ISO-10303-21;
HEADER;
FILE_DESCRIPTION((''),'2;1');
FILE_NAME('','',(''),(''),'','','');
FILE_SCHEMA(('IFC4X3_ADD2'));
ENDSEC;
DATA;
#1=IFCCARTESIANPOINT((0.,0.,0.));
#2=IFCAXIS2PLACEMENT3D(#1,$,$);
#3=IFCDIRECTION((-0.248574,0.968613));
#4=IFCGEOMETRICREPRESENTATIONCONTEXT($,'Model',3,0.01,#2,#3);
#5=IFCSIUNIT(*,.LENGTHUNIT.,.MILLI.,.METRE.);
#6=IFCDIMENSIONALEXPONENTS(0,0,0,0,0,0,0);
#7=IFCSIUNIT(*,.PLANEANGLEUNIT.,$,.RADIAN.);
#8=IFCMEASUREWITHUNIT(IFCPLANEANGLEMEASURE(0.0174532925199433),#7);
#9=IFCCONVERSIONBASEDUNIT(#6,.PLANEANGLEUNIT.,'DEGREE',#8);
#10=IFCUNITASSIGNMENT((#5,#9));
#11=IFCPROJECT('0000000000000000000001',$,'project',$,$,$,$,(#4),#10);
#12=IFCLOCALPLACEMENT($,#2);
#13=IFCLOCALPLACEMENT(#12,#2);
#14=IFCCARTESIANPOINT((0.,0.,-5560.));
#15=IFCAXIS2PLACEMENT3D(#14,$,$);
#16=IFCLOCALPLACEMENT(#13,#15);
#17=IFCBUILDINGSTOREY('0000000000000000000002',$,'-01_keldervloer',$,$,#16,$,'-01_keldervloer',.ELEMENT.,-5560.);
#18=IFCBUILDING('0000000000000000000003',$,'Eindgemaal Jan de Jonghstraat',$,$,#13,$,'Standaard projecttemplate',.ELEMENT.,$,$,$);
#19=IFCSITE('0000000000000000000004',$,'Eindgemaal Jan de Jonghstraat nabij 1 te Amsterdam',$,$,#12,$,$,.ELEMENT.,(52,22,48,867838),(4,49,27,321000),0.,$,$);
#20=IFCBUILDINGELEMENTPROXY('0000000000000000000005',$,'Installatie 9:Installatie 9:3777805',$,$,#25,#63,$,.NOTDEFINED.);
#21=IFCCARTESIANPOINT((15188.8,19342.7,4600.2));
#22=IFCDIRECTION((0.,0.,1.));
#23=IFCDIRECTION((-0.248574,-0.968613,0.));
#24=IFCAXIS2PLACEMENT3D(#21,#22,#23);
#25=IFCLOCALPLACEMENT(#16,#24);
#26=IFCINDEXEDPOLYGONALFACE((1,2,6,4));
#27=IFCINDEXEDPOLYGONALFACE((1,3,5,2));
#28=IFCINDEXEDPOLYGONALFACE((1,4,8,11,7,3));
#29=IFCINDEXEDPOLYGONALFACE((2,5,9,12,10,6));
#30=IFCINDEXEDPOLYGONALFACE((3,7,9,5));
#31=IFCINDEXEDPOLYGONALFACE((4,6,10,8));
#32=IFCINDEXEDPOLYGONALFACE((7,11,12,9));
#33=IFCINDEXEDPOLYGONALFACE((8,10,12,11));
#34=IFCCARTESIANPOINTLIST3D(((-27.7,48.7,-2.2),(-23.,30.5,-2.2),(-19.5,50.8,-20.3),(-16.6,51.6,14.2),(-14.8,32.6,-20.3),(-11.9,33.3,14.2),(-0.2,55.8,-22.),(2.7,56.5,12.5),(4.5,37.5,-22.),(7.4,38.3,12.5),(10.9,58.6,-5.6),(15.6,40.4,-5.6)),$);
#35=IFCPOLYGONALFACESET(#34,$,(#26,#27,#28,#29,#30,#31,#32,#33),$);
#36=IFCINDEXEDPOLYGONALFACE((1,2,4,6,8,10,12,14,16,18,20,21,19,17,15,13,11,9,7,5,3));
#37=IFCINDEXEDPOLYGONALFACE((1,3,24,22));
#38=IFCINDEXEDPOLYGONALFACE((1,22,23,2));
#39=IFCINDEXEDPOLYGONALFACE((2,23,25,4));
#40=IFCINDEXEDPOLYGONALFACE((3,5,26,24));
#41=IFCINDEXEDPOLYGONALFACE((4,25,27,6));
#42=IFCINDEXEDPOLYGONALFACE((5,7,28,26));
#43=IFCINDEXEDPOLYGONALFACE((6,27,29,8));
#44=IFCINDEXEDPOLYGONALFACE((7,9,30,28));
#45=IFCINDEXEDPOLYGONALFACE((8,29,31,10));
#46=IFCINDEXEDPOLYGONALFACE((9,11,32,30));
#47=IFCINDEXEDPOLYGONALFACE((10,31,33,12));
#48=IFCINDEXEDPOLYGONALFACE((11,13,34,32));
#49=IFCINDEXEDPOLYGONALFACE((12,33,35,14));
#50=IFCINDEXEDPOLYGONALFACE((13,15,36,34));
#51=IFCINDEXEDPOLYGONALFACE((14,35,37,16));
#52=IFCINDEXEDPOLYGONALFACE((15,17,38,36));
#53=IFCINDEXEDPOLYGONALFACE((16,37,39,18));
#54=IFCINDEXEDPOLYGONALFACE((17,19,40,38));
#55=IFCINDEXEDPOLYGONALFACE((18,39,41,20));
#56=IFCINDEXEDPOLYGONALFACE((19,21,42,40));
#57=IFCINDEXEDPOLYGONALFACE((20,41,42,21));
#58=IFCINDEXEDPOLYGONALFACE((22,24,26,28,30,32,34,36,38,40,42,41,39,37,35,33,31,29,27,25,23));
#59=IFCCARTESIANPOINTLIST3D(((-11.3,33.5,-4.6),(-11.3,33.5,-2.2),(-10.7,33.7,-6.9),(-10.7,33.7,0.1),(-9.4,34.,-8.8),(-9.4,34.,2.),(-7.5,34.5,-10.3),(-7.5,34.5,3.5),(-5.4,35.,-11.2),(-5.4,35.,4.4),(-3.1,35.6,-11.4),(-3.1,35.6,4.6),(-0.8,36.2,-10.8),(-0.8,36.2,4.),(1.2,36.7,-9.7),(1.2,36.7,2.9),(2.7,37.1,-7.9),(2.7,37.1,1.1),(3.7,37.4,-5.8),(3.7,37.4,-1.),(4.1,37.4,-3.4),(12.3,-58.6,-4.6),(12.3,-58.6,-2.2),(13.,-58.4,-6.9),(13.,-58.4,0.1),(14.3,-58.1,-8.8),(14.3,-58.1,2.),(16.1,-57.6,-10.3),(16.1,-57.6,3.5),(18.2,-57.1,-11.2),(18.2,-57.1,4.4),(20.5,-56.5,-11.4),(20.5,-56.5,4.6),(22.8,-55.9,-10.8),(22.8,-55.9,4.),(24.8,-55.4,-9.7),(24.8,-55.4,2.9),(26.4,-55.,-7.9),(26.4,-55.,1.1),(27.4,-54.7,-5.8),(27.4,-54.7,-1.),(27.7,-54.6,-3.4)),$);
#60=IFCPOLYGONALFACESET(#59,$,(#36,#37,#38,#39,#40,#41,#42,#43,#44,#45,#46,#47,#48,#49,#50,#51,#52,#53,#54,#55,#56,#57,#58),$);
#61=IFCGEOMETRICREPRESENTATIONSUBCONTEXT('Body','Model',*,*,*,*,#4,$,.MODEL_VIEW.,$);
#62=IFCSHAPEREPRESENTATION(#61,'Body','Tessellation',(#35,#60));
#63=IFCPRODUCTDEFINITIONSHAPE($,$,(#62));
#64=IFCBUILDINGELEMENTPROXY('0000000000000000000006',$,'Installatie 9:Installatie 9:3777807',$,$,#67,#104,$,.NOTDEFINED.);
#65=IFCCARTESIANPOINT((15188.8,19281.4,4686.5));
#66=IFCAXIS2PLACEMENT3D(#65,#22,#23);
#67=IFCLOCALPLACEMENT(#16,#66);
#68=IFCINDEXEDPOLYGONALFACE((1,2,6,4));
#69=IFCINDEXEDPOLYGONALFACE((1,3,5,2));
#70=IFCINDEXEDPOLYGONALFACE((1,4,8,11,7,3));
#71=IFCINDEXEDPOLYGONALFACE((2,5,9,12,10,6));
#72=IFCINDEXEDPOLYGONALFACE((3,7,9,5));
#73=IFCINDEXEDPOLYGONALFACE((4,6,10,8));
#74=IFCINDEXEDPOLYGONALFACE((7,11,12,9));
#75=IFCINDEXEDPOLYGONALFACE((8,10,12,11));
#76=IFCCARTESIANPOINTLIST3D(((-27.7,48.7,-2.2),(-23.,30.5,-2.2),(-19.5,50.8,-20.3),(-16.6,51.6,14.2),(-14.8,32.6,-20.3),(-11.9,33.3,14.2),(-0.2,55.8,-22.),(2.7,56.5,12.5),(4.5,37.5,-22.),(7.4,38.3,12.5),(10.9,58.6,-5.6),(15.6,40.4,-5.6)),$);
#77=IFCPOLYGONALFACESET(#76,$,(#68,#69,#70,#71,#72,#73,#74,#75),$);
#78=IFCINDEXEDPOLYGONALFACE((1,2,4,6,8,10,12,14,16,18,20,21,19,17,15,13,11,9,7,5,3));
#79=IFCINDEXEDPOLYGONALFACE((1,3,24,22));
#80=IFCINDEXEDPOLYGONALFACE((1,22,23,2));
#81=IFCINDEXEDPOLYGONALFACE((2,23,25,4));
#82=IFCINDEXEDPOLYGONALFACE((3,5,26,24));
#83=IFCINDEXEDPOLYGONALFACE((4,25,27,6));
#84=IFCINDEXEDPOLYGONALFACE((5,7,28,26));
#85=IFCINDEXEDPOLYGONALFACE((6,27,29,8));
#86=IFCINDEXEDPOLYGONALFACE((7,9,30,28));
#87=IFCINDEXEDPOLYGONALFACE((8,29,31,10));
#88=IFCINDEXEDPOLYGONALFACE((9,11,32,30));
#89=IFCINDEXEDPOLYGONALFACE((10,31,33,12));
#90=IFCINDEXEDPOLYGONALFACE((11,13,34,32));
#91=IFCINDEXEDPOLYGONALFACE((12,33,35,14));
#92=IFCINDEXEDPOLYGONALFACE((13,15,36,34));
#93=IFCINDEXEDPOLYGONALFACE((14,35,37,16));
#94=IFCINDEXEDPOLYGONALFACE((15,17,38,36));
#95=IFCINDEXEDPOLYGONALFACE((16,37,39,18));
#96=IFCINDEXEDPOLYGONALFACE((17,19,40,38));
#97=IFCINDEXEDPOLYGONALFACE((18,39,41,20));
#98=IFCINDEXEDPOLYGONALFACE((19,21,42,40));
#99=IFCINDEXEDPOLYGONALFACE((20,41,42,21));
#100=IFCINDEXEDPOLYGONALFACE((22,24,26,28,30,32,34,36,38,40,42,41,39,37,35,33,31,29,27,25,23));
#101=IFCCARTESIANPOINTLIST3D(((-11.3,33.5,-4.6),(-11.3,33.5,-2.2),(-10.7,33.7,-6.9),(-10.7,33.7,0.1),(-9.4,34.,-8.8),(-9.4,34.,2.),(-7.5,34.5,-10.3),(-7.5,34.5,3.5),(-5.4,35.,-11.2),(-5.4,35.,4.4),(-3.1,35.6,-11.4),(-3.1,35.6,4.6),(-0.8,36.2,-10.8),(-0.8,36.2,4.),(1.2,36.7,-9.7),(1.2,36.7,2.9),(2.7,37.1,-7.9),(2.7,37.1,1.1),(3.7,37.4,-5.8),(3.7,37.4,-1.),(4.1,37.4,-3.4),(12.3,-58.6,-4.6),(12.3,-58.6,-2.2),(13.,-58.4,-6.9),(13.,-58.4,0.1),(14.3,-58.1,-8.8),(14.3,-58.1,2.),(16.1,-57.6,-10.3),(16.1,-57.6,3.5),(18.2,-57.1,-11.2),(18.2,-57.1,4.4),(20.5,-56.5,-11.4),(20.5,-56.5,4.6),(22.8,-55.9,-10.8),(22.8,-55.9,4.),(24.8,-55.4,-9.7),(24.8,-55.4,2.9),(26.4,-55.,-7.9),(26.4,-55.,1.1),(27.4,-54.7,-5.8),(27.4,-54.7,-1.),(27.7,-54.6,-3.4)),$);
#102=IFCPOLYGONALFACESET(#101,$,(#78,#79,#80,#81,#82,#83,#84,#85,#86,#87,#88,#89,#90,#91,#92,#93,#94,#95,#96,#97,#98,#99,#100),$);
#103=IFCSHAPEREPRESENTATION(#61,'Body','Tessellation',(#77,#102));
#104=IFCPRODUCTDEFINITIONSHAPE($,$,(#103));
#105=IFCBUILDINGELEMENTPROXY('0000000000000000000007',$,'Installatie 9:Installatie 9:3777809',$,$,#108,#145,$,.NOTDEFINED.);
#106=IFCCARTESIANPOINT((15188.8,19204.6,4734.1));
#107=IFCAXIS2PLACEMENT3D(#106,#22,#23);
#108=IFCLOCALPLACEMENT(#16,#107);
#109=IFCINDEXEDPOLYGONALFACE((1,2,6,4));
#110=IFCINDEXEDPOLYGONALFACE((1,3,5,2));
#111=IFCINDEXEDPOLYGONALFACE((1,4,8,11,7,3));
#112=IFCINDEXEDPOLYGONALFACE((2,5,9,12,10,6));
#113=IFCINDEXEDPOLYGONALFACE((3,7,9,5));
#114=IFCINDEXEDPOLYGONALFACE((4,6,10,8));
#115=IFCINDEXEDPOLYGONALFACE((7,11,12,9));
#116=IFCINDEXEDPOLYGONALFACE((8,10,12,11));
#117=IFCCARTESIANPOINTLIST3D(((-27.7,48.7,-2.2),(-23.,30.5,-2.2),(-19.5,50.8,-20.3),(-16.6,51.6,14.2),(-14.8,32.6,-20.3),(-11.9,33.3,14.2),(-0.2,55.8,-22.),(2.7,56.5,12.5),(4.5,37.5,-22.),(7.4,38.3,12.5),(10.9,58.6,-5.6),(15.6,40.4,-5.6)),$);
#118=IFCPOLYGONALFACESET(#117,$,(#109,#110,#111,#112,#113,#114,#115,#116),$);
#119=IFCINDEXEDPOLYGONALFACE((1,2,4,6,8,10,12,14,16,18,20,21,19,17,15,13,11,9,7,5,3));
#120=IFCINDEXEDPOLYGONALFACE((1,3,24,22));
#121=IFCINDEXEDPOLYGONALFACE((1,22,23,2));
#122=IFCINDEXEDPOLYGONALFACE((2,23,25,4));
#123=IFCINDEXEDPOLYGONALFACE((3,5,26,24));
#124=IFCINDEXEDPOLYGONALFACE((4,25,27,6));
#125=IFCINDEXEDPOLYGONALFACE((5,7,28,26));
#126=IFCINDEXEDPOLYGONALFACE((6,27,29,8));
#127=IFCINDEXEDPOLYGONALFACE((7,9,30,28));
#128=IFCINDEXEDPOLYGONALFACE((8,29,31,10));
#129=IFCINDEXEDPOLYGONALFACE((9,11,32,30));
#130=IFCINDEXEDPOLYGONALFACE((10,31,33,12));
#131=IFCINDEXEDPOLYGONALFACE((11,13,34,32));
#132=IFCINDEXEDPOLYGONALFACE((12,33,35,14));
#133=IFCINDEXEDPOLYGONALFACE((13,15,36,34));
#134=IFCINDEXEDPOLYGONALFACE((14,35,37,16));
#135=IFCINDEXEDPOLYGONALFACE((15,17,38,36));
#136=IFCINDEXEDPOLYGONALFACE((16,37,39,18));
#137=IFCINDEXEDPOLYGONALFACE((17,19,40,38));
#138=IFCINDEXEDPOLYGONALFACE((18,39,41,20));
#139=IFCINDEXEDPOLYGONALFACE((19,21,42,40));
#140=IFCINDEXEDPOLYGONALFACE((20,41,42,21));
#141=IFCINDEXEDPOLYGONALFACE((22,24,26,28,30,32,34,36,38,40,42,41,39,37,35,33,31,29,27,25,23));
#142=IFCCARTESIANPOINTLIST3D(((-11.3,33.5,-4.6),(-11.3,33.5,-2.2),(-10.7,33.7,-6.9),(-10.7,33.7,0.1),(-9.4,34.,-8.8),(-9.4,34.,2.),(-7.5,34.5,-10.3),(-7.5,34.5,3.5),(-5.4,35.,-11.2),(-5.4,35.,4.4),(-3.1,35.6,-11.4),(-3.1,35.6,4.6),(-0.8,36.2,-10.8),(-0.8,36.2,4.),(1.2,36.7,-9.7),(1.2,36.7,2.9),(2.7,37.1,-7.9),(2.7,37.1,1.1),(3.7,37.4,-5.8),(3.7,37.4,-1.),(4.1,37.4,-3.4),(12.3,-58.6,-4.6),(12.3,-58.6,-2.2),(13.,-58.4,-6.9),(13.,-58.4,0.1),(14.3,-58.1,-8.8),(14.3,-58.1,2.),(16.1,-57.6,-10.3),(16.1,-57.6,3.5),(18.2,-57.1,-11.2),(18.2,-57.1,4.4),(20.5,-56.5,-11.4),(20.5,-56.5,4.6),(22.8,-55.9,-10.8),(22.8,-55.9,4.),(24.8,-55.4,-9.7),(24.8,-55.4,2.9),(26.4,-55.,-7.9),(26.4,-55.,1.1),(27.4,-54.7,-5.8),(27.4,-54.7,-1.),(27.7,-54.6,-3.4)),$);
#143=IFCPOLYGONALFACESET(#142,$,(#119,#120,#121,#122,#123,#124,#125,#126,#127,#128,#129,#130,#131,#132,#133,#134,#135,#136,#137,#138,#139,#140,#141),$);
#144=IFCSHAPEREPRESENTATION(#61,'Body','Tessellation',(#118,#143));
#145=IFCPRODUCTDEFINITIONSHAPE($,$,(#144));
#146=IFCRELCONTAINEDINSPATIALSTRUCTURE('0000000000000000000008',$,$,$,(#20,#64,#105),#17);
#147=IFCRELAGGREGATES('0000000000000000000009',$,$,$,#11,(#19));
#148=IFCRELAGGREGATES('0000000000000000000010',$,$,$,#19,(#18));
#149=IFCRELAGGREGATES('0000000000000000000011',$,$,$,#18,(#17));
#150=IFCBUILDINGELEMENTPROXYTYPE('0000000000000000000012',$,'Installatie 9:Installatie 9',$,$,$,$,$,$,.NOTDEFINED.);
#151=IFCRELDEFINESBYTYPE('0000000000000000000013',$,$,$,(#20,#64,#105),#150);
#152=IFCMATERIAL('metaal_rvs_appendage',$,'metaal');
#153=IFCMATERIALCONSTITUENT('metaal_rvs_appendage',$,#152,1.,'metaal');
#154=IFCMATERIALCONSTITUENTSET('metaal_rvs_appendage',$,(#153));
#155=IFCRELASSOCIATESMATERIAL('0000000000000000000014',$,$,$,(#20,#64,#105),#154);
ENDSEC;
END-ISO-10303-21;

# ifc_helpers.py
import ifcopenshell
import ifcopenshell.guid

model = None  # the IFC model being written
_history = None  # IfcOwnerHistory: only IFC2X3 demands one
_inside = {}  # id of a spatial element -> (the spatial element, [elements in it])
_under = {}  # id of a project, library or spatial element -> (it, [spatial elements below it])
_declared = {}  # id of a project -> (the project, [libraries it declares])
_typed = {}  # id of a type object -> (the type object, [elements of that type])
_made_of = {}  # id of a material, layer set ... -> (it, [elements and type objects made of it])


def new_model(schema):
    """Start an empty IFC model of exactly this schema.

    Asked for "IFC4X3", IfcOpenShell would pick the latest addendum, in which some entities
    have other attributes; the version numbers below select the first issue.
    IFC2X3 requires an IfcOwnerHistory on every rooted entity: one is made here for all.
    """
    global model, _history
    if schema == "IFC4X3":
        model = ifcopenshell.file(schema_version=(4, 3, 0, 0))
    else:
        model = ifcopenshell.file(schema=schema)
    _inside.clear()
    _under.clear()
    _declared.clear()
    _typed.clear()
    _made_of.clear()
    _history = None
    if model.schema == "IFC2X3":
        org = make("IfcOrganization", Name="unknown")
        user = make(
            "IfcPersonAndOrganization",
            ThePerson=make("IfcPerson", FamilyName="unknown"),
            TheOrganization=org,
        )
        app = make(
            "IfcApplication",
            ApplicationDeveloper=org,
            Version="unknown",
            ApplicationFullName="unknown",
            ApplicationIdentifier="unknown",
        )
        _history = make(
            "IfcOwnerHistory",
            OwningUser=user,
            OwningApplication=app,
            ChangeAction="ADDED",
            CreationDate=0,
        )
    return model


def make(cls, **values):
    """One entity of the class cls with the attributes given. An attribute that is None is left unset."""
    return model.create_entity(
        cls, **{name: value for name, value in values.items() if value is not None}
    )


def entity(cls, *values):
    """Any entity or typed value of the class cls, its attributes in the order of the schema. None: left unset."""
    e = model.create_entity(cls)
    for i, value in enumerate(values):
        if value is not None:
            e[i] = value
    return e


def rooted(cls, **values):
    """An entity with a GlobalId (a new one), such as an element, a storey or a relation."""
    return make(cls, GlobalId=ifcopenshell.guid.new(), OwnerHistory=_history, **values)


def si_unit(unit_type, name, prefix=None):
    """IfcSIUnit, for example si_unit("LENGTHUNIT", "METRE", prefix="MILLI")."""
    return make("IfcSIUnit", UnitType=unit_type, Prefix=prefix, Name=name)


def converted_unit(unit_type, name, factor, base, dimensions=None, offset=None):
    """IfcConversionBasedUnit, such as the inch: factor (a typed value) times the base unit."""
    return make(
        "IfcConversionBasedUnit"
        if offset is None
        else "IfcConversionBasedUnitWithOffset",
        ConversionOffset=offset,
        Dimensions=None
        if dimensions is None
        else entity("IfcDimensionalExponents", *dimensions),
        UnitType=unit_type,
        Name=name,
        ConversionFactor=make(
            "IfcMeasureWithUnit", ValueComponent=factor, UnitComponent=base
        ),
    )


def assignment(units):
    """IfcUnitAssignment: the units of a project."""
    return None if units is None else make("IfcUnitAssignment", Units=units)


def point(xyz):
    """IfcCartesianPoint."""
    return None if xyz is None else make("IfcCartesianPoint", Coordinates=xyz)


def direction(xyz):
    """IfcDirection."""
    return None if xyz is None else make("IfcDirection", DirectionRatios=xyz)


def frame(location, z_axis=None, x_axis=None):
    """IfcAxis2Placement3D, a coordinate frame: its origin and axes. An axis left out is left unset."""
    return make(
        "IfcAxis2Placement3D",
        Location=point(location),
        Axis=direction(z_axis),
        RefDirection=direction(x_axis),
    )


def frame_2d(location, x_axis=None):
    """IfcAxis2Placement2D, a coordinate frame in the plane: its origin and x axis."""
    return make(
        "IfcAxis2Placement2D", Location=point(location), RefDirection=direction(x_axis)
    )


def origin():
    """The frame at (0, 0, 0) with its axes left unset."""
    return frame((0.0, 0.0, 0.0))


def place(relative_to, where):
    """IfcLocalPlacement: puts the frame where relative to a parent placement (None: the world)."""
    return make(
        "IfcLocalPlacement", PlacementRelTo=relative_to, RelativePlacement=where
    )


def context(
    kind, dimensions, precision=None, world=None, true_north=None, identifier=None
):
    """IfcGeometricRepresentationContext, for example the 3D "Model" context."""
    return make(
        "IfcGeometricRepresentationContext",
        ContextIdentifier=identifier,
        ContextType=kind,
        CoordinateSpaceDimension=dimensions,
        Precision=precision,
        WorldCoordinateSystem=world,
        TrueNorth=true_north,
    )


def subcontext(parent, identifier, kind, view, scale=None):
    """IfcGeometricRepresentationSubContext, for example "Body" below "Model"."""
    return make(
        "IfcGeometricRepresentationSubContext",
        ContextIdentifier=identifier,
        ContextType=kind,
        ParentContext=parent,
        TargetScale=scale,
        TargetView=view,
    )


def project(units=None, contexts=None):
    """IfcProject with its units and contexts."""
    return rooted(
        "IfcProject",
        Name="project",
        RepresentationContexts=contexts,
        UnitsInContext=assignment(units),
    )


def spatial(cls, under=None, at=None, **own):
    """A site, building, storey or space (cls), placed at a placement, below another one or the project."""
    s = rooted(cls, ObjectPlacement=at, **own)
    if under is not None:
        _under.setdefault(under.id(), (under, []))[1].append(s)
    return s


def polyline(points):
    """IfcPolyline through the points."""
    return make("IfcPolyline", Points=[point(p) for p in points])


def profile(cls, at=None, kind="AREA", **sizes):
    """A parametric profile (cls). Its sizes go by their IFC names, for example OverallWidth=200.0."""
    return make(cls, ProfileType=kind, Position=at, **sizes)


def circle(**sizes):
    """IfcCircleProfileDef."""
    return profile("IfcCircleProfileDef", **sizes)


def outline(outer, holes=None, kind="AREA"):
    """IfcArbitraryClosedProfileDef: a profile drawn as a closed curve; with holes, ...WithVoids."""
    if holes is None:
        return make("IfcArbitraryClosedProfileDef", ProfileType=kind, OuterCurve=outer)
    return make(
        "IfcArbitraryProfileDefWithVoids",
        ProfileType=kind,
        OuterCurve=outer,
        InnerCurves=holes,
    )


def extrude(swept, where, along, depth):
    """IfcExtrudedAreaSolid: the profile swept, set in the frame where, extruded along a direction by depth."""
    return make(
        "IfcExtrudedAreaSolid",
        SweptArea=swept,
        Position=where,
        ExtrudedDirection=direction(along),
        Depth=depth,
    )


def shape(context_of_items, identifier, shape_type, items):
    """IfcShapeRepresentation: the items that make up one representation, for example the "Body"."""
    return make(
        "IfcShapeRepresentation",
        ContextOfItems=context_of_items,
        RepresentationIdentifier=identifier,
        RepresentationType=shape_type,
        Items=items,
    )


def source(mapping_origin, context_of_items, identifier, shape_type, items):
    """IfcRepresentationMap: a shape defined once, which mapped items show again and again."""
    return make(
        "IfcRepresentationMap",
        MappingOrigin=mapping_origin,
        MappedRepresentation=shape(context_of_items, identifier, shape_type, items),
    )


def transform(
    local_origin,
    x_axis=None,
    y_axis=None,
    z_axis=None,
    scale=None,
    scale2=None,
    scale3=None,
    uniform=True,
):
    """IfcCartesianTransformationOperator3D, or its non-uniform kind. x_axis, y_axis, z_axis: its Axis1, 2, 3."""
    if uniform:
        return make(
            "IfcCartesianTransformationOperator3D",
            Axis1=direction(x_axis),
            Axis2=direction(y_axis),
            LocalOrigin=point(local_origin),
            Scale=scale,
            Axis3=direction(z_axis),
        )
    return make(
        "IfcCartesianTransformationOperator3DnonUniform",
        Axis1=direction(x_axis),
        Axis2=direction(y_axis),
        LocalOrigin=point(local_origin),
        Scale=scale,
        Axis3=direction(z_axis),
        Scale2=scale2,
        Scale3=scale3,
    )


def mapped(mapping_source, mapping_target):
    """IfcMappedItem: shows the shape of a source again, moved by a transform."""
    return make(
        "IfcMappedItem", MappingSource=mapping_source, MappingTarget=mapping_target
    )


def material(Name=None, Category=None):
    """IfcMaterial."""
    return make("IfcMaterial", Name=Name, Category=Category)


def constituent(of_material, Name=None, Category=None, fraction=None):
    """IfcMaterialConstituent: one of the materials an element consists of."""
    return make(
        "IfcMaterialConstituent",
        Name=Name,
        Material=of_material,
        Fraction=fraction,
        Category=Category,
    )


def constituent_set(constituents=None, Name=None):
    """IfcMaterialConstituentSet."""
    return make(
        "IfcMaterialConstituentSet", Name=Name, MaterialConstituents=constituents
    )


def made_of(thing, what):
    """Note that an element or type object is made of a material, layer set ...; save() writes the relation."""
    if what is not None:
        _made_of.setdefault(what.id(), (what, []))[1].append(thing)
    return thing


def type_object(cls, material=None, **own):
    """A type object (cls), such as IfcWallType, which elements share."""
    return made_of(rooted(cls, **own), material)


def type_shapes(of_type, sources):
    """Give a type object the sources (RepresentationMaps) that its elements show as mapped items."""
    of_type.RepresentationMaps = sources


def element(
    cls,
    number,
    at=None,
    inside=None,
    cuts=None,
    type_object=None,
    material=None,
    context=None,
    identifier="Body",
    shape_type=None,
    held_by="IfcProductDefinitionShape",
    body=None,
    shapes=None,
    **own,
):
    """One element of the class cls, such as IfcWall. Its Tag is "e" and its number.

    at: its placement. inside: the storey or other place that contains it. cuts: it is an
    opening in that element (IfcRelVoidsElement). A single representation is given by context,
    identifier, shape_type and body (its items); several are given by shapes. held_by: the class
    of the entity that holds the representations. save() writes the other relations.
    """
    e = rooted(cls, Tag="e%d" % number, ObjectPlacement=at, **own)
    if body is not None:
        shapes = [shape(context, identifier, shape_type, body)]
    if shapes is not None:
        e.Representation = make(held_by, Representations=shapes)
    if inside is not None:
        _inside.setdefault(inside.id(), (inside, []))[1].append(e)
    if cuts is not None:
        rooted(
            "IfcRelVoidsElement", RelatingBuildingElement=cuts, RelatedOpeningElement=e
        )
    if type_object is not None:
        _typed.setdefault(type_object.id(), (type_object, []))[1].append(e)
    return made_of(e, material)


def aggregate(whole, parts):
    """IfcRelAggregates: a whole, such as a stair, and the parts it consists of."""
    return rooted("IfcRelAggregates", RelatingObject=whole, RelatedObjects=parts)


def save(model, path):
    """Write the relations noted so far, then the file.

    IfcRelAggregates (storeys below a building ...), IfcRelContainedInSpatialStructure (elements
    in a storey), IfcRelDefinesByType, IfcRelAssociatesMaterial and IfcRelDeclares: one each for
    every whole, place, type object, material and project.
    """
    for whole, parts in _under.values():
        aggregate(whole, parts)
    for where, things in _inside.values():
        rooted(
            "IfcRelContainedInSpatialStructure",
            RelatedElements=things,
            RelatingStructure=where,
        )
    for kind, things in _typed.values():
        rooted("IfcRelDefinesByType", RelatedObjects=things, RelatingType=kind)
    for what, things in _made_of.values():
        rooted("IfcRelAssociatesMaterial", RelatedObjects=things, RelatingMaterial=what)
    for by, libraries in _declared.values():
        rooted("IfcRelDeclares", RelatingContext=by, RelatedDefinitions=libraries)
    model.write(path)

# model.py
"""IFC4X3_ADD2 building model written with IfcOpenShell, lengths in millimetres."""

from ifc_helpers import new_model, entity, si_unit, converted_unit, direction, frame, frame_2d, origin, place, context, subcontext, project, spatial, polyline, circle, outline, extrude, source, transform, mapped, material, constituent, constituent_set, type_object, type_shapes, element, save


model = new_model("IFC4X3_ADD2")

# Units and contexts
model_context = context("Model", 3, precision=0.01, world=origin(), true_north=direction((-0.248574, 0.968613)))
body_context = subcontext(model_context, "Body", "Model", "MODEL_VIEW")
ifc_project = project(units=[si_unit("LENGTHUNIT", "METRE", prefix="MILLI"), converted_unit("PLANEANGLEUNIT", "DEGREE", entity("IfcPlaneAngleMeasure", 0.0174532925199433), si_unit("PLANEANGLEUNIT", "RADIAN"), dimensions=[0, 0, 0, 0, 0, 0, 0])], contexts=[model_context])

# Site, building, storey
site_placement = place(None, origin())
site = spatial("IfcSite", under=ifc_project, at=site_placement, Name="Eindgemaal Jan de Jonghstraat nabij 1 te Amsterdam", CompositionType="ELEMENT", RefLatitude=(52, 22, 48, 867838), RefLongitude=(4, 49, 27, 321000), RefElevation=0.0)
building_placement = place(site_placement, origin())
building = spatial("IfcBuilding", under=site, at=building_placement, Name="Eindgemaal Jan de Jonghstraat", LongName="Standaard projecttemplate", CompositionType="ELEMENT")
storey_placement = place(building_placement, frame((0.0, 0.0, -5560.0)))
storey = spatial("IfcBuildingStorey", under=building, at=storey_placement, Name="-01_keldervloer", LongName="-01_keldervloer", CompositionType="ELEMENT", Elevation=-5560.0)

# Building element proxies
ifc_material_1 = material(Name="metaal_rvs_appendage", Category="metaal")
ifc_constituent_1 = constituent(ifc_material_1, Name="metaal_rvs_appendage", Category="metaal", fraction=1.0)
ifc_constituent_set_1 = constituent_set(constituents=[ifc_constituent_1], Name="metaal_rvs_appendage")
building_element_proxy_type = type_object("IfcBuildingElementProxyType", Name="Installatie 9:Installatie 9", PredefinedType="NOTDEFINED")
shared_shape_1 = source(origin(), body_context, "Body", "SweptSolid", [
    extrude(outline(polyline([(-10.0, -17.3), (10.0, -17.3), (20.0, 0.0), (10.0, 17.3), (-10.0, 17.3), (-20.0, 0.0), (-10.0, -17.3)])), frame((-3.7, 35.4, -3.9), z_axis=(-0.248574, 0.968613, 0.0), x_axis=(-0.555573, -0.142576, -0.819152)), (0.0, 0.0, 1.0), 18.8),
    extrude(circle(Radius=8.0, at=frame_2d((0.0, 0.0), x_axis=(1.0, 0.0))), frame((20.0, -56.6, -3.4), z_axis=(-0.248574, 0.968613, 0.0), x_axis=(0.968613, 0.248574, 0.0)), (0.0, 0.0, 1.0), 95.1),
])
type_shapes(building_element_proxy_type, [shared_shape_1])
for number, where, z_axis, x_axis, name in (
    (1, (15188.8, 19342.7, 4600.2), (0.0, 0.0, 1.0), (-0.248574, -0.968613, 0.0), "Installatie 9:Installatie 9:3777805"),
    (2, (15188.8, 19281.4, 4686.5), (0.0, 0.0, 1.0), (-0.248574, -0.968613, 0.0), "Installatie 9:Installatie 9:3777807"),
    (3, (15188.8, 19204.6, 4734.1), (0.0, 0.0, 1.0), (-0.248574, -0.968613, 0.0), "Installatie 9:Installatie 9:3777809"),
):
    element("IfcBuildingElementProxy", number, at=place(storey_placement, frame(where, z_axis=z_axis, x_axis=x_axis)), inside=storey, type_object=building_element_proxy_type, material=ifc_constituent_set_1, Name=name, PredefinedType="NOTDEFINED", context=body_context, shape_type="MappedRepresentation", body=[
        mapped(shared_shape_1, transform((0.0, 0.0, 0.0), scale=1.0)),
    ])

save(model, "model.ifc")
